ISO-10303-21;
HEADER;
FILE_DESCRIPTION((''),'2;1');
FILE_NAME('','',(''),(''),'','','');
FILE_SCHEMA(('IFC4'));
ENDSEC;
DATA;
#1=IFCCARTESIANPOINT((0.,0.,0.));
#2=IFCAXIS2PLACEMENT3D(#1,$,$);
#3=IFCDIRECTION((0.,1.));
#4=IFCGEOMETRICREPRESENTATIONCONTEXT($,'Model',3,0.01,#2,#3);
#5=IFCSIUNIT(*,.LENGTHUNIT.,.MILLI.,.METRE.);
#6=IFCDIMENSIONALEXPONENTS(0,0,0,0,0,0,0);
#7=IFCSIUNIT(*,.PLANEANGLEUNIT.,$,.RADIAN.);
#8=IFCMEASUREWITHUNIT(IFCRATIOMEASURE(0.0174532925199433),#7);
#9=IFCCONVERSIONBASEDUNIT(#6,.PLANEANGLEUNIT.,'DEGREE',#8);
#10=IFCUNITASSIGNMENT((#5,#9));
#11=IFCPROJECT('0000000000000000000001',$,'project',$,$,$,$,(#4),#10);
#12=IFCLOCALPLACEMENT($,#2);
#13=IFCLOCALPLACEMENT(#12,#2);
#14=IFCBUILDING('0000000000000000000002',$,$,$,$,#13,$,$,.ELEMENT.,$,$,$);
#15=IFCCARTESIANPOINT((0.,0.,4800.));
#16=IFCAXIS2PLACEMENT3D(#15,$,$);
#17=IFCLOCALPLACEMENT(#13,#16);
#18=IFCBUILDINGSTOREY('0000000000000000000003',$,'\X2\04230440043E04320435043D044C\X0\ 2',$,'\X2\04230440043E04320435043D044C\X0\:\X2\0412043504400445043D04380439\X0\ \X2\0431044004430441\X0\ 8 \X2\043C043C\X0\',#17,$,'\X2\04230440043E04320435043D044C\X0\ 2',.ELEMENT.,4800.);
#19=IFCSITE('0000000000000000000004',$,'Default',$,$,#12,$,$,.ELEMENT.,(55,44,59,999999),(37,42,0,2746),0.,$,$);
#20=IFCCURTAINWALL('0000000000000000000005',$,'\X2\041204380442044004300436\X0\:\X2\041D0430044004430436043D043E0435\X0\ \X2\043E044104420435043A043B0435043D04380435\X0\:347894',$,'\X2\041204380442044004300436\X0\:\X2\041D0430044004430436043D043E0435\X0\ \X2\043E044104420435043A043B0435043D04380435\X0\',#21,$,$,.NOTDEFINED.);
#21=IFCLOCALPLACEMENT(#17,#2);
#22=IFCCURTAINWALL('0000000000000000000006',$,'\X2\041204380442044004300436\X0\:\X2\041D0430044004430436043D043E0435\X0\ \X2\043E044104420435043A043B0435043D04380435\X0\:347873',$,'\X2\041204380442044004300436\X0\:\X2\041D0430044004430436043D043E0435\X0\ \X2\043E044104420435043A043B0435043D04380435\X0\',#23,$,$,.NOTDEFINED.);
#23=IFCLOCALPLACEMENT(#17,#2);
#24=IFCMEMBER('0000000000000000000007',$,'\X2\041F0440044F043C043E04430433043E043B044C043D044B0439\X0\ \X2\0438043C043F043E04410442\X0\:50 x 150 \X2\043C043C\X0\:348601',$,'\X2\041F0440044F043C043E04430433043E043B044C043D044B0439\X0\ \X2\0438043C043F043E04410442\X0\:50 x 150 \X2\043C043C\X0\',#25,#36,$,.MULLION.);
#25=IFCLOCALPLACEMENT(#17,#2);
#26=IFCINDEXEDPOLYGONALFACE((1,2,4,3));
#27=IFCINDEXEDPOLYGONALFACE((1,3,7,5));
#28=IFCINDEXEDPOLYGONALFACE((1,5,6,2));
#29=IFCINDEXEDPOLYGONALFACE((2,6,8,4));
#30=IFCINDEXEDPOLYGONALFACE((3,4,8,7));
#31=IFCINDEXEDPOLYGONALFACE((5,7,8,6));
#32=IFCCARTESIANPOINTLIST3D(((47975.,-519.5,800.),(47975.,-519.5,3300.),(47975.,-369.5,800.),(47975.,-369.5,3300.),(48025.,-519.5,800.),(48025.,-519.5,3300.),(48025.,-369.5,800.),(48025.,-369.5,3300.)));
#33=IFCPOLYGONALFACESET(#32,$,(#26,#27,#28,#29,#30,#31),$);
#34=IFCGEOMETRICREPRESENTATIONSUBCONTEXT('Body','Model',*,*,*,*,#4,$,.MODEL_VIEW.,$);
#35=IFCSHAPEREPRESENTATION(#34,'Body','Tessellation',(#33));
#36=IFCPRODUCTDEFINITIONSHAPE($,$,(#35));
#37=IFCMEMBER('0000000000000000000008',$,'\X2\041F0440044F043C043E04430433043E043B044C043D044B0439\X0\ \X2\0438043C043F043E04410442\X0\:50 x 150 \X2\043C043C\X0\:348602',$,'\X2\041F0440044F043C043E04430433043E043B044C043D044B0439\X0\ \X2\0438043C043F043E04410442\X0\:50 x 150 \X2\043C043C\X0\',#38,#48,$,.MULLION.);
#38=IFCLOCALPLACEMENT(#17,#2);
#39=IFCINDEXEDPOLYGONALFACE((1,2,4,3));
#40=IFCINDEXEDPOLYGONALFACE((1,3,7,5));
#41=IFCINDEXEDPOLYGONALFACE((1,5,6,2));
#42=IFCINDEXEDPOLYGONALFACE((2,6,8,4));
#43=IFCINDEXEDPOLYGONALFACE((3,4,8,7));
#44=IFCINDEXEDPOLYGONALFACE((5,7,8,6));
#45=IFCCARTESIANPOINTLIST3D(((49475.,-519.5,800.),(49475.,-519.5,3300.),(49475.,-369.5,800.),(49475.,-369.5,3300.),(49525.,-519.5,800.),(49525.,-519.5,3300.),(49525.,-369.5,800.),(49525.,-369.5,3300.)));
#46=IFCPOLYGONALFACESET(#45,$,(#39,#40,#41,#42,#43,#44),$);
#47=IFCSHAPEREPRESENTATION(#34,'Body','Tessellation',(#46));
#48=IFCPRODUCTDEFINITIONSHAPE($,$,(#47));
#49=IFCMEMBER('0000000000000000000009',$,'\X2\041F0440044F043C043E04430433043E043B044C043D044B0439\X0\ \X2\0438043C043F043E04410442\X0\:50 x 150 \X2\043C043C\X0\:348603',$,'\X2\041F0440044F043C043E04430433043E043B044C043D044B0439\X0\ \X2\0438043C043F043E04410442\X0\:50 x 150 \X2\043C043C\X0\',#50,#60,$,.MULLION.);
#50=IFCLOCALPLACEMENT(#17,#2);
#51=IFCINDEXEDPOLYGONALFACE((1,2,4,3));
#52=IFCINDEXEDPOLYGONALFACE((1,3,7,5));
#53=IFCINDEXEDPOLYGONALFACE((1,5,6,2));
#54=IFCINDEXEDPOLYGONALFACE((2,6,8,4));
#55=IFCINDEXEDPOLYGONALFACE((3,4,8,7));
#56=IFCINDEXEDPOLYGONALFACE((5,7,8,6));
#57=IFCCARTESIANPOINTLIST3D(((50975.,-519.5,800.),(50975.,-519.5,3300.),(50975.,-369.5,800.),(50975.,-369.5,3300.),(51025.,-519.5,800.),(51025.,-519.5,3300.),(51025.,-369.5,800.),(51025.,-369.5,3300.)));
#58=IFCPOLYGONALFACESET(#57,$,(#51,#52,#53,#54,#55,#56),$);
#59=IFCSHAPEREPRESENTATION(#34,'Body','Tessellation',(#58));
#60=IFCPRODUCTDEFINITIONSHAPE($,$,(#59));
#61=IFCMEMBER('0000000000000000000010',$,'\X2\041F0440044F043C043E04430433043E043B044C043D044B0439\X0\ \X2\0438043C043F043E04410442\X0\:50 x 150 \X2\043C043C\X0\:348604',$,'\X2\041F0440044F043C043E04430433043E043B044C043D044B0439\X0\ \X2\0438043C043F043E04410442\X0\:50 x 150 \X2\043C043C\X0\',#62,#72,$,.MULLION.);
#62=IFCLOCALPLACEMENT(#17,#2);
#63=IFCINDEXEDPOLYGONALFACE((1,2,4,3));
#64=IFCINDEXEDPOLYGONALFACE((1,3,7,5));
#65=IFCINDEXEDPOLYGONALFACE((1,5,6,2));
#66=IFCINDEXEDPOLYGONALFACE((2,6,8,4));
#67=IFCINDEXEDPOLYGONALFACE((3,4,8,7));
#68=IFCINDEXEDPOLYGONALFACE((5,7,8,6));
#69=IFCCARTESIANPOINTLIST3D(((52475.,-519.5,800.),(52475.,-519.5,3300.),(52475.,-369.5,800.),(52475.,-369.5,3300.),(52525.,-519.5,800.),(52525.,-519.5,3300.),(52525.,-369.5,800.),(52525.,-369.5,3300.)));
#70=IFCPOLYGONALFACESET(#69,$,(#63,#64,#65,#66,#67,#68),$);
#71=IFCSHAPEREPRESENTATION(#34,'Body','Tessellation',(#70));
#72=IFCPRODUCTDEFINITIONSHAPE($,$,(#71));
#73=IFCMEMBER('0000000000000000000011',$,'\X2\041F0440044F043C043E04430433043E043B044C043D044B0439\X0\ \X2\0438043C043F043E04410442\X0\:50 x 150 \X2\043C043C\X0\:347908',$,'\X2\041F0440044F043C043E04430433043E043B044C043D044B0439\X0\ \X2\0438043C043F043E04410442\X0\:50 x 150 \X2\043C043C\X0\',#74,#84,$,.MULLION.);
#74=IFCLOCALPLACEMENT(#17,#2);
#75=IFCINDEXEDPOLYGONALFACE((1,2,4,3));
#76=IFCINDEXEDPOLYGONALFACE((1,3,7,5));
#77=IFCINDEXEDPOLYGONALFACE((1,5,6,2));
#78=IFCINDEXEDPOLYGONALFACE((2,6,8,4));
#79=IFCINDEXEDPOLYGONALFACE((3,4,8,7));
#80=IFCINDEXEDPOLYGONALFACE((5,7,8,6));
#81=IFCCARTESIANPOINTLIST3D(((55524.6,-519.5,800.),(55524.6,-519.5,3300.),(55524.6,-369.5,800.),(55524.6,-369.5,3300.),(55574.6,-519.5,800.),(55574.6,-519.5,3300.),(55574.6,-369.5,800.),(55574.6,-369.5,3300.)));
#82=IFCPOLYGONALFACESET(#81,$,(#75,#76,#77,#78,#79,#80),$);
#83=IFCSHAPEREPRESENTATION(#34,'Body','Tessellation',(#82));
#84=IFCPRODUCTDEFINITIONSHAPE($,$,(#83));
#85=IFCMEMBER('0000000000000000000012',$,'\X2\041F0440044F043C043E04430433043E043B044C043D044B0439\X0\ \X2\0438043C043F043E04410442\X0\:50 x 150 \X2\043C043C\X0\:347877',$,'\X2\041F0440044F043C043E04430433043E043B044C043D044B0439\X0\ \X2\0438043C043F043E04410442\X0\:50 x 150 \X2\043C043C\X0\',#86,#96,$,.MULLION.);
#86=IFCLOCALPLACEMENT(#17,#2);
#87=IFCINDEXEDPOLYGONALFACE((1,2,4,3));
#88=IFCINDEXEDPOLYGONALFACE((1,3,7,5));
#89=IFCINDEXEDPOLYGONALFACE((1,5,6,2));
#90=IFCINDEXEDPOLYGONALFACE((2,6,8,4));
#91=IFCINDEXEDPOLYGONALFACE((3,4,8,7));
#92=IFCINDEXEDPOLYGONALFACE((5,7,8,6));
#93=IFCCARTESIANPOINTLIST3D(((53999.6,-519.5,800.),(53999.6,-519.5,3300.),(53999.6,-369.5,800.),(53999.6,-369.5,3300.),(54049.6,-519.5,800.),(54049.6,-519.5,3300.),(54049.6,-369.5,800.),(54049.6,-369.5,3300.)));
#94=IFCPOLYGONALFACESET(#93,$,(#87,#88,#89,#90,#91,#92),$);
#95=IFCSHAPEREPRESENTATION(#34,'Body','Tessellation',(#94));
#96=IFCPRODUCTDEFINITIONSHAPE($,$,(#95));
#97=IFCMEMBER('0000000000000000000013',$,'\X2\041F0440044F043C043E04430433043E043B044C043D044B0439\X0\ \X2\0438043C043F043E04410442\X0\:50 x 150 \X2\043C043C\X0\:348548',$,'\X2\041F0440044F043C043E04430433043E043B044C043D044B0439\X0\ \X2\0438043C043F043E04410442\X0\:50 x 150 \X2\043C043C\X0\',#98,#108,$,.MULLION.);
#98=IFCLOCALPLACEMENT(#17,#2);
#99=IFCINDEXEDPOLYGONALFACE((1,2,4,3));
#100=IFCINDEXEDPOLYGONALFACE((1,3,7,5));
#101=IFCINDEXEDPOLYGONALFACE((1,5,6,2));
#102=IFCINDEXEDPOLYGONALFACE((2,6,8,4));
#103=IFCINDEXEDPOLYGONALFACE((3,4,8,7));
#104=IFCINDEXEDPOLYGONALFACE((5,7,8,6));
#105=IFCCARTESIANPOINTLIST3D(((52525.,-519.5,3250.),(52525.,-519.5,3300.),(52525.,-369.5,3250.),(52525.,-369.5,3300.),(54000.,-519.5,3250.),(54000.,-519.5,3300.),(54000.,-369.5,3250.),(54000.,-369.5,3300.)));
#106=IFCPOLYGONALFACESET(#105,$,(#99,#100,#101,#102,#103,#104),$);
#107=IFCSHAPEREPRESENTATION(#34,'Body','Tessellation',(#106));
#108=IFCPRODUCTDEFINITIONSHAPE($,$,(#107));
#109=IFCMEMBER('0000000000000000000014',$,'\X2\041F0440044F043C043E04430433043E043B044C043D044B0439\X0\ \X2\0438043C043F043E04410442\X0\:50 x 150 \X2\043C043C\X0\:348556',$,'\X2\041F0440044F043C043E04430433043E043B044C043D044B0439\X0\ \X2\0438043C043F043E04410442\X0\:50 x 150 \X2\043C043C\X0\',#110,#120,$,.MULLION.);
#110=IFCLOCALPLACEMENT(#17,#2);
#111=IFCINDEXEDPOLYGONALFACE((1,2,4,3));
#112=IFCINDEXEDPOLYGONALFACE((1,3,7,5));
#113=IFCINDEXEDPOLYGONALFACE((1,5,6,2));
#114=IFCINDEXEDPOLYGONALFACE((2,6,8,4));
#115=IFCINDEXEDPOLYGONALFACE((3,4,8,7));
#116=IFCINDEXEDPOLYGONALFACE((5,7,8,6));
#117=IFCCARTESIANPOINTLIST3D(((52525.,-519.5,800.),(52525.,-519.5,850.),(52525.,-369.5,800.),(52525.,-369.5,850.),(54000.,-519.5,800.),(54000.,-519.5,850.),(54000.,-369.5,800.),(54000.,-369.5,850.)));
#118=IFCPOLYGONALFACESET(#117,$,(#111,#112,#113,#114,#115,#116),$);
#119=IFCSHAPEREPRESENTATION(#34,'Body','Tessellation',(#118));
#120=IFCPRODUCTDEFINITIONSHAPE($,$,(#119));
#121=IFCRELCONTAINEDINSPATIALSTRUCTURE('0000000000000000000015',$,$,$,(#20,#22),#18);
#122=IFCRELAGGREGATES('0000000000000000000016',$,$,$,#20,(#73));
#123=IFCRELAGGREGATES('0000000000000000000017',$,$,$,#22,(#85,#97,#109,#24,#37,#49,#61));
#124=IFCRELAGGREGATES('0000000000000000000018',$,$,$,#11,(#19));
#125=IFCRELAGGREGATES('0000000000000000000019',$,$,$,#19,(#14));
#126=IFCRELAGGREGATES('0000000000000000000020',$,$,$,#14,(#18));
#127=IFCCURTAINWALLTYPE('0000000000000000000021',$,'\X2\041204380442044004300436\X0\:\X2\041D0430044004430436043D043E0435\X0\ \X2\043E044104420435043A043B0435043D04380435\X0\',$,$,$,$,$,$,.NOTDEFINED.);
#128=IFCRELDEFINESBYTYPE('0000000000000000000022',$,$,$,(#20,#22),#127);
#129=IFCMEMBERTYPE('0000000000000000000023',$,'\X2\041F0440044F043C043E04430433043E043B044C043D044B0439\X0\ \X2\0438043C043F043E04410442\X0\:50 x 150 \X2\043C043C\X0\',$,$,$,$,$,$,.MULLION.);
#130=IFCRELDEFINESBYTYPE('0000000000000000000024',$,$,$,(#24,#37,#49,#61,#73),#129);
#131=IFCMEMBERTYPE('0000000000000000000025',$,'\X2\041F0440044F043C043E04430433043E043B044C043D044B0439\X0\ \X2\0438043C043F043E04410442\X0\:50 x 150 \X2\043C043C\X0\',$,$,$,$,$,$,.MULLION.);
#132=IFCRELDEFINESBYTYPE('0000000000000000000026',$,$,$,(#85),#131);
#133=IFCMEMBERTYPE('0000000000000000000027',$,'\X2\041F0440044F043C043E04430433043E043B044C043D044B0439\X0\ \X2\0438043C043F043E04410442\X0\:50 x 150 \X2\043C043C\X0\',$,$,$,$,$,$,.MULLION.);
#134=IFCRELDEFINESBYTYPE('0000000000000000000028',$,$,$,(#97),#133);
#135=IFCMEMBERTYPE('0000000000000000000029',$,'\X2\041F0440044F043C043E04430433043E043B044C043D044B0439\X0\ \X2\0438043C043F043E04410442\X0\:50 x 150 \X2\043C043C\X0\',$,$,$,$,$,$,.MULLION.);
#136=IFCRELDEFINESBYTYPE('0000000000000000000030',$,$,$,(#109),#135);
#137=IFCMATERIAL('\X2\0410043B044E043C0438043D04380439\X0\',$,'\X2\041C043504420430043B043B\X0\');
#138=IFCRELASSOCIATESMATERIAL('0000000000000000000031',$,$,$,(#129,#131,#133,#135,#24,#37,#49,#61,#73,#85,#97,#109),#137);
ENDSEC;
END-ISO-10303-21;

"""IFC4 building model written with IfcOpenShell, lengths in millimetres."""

from ifc_helpers import new_model, entity, si_unit, converted_unit, direction, frame, origin, origin_2d_with_axis, place, context, subcontext, project, spatial, rectangle, extrude, source, transform, mapped, material, material_profile, profile_set, profile_usage, type_object, type_shapes, element, aggregate, save


model = new_model("IFC4")

# Units and contexts
model_context = context("Model", 3, precision=0.01, world=origin(), true_north=direction((0.0, 1.0)))
body_context = subcontext(model_context, "Body", "Model", "MODEL_VIEW")
ifc_project = project(units=[si_unit("LENGTHUNIT", "METRE", prefix="MILLI"), converted_unit("PLANEANGLEUNIT", "DEGREE", entity("IfcRatioMeasure", 0.0174532925199433), si_unit("PLANEANGLEUNIT", "RADIAN"), dimensions=[0, 0, 0, 0, 0, 0, 0])], contexts=[model_context])

# Site, building, storey
site_placement = place(None, origin())
site = spatial("IfcSite", under=ifc_project, at=site_placement, Name="Default", CompositionType="ELEMENT", RefLatitude=(55, 44, 59, 999999), RefLongitude=(37, 42, 0, 2746), RefElevation=0.0)
building_placement = place(site_placement, origin())
building = spatial("IfcBuilding", under=site, at=building_placement, CompositionType="ELEMENT")
storey_placement = place(building_placement, frame((0.0, 0.0, 4800.0)))
storey = spatial("IfcBuildingStorey", under=building, at=storey_placement, Name="Уровень 2", ObjectType="Уровень:Верхний брус 8 мм", LongName="Уровень 2", CompositionType="ELEMENT", Elevation=4800.0)

# Curtain walls
curtain_wall_type = type_object("IfcCurtainWallType", Name="Витраж:Наружное остекление", PredefinedType="NOTDEFINED")
curtain_wall_1_placement = place(storey_placement, frame((0.0, 0.0, -4800.0)))
curtain_wall_1 = element("IfcCurtainWall", 1, at=curtain_wall_1_placement, inside=storey, type_object=curtain_wall_type, Name="Витраж:Наружное остекление:347894", ObjectType="Витраж:Наружное остекление", PredefinedType="NOTDEFINED")
ifc_material = material(Name="Алюминий", Category="Металл")
ifc_material_profile = material_profile(ifc_material, rectangle(XDim=150.0, YDim=50.0, at=origin_2d_with_axis()), Name="50 x 150 мм")
ifc_profile_set = profile_set([ifc_material_profile], Name="50 x 150 мм")
curtain_wall_2_placement = place(storey_placement, frame((0.0, 0.0, -4800.0)))
curtain_wall_2 = element("IfcCurtainWall", 2, at=curtain_wall_2_placement, inside=storey, type_object=curtain_wall_type, Name="Витраж:Наружное остекление:347873", ObjectType="Витраж:Наружное остекление", PredefinedType="NOTDEFINED")

# Members
member_type_1 = type_object("IfcMemberType", Name="Прямоугольный импост:50 x 150 мм", PredefinedType="MULLION", material=ifc_profile_set)
shared_shape_1 = source(origin(), body_context, "Body", "SweptSolid", [
    extrude(rectangle(XDim=150.0, YDim=50.0, at=origin_2d_with_axis()), frame((0.0, 0.0, -2500.0), z_axis=(0.0, 0.0, 1.0), x_axis=(0.0, -1.0, 0.0)), (0.0, 0.0, 1.0), 2500.0),
])
type_shapes(member_type_1, [shared_shape_1])
ifc_profile_usage_1 = profile_usage(ifc_profile_set)
member_1_placement = place(storey_placement, frame((48000.0, -444.5, 800.0), z_axis=(0.0, 0.0, -1.0), x_axis=(1.0, 0.0, 0.0)))
member_1 = element("IfcMember", 3, at=member_1_placement, type_object=member_type_1, material=ifc_profile_usage_1, Name="Прямоугольный импост:50 x 150 мм:348601", ObjectType="Прямоугольный импост:50 x 150 мм", PredefinedType="MULLION", context=body_context, shape_type="MappedRepresentation", body=[
    mapped(shared_shape_1, transform((0.0, 0.0, 0.0), scale=1.0)),
])
ifc_profile_usage_2 = profile_usage(ifc_profile_set)
member_2_placement = place(storey_placement, frame((49500.0, -444.5, 800.0), z_axis=(0.0, 0.0, -1.0), x_axis=(1.0, 0.0, 0.0)))
member_2 = element("IfcMember", 4, at=member_2_placement, type_object=member_type_1, material=ifc_profile_usage_2, Name="Прямоугольный импост:50 x 150 мм:348602", ObjectType="Прямоугольный импост:50 x 150 мм", PredefinedType="MULLION", context=body_context, shape_type="MappedRepresentation", body=[
    mapped(shared_shape_1, transform((0.0, 0.0, 0.0), scale=1.0)),
])
ifc_profile_usage_3 = profile_usage(ifc_profile_set)
member_3_placement = place(storey_placement, frame((51000.0, -444.5, 800.0), z_axis=(0.0, 0.0, -1.0), x_axis=(1.0, 0.0, 0.0)))
member_3 = element("IfcMember", 5, at=member_3_placement, type_object=member_type_1, material=ifc_profile_usage_3, Name="Прямоугольный импост:50 x 150 мм:348603", ObjectType="Прямоугольный импост:50 x 150 мм", PredefinedType="MULLION", context=body_context, shape_type="MappedRepresentation", body=[
    mapped(shared_shape_1, transform((0.0, 0.0, 0.0), scale=1.0)),
])
ifc_profile_usage_4 = profile_usage(ifc_profile_set)
member_4_placement = place(storey_placement, frame((52500.0, -444.5, 800.0), z_axis=(0.0, 0.0, -1.0), x_axis=(1.0, 0.0, 0.0)))
member_4 = element("IfcMember", 6, at=member_4_placement, type_object=member_type_1, material=ifc_profile_usage_4, Name="Прямоугольный импост:50 x 150 мм:348604", ObjectType="Прямоугольный импост:50 x 150 мм", PredefinedType="MULLION", context=body_context, shape_type="MappedRepresentation", body=[
    mapped(shared_shape_1, transform((0.0, 0.0, 0.0), scale=1.0)),
])
ifc_profile_usage_5 = profile_usage(ifc_profile_set)
member_5_placement = place(storey_placement, frame((55549.6, -444.5, 800.0), z_axis=(0.0, 0.0, -1.0), x_axis=(1.0, 0.0, 0.0)))
member_5 = element("IfcMember", 7, at=member_5_placement, type_object=member_type_1, material=ifc_profile_usage_5, Name="Прямоугольный импост:50 x 150 мм:347908", ObjectType="Прямоугольный импост:50 x 150 мм", PredefinedType="MULLION", context=body_context, shape_type="MappedRepresentation", body=[
    mapped(shared_shape_1, transform((0.0, 0.0, 0.0), scale=1.0)),
])
aggregate(curtain_wall_1, [member_5])
ifc_profile_usage_6 = profile_usage(ifc_profile_set)
member_type_2 = type_object("IfcMemberType", Name="Прямоугольный импост:50 x 150 мм", PredefinedType="MULLION", material=ifc_profile_set)
shared_shape_2 = source(origin(), body_context, "Body", "SweptSolid", [
    extrude(rectangle(XDim=150.0, YDim=50.0, at=origin_2d_with_axis()), frame((-25.0, 0.0, -2500.0), z_axis=(0.0, 0.0, 1.0), x_axis=(0.0, -1.0, 0.0)), (0.0, 0.0, 1.0), 2500.0),
])
type_shapes(member_type_2, [shared_shape_2])
member_6_placement = place(storey_placement, frame((54049.6, -444.5, 800.0), z_axis=(0.0, 0.0, -1.0), x_axis=(1.0, 0.0, 0.0)))
member_6 = element("IfcMember", 8, at=member_6_placement, type_object=member_type_2, material=ifc_profile_usage_6, Name="Прямоугольный импост:50 x 150 мм:347877", ObjectType="Прямоугольный импост:50 x 150 мм", PredefinedType="MULLION", context=body_context, shape_type="MappedRepresentation", body=[
    mapped(shared_shape_2, transform((0.0, 0.0, 0.0), scale=1.0)),
])
ifc_profile_usage_7 = profile_usage(ifc_profile_set)
member_type_3 = type_object("IfcMemberType", Name="Прямоугольный импост:50 x 150 мм", PredefinedType="MULLION", material=ifc_profile_set)
shared_shape_3 = source(origin(), body_context, "Body", "SweptSolid", [
    extrude(rectangle(XDim=150.0, YDim=50.0, at=origin_2d_with_axis()), frame((-25.0, 0.0, -1475.0), z_axis=(0.0, 0.0, 1.0), x_axis=(0.0, -1.0, 0.0)), (0.0, 0.0, 1.0), 1475.0),
])
type_shapes(member_type_3, [shared_shape_3])
member_7_placement = place(storey_placement, frame((54000.0, -444.5, 3300.0), z_axis=(1.0, 0.0, 0.0), x_axis=(0.0, 0.0, 1.0)))
member_7 = element("IfcMember", 9, at=member_7_placement, type_object=member_type_3, material=ifc_profile_usage_7, Name="Прямоугольный импост:50 x 150 мм:348548", ObjectType="Прямоугольный импост:50 x 150 мм", PredefinedType="MULLION", context=body_context, shape_type="MappedRepresentation", body=[
    mapped(shared_shape_3, transform((0.0, 0.0, 0.0), scale=1.0)),
])
ifc_profile_usage_8 = profile_usage(ifc_profile_set)
member_type_4 = type_object("IfcMemberType", Name="Прямоугольный импост:50 x 150 мм", PredefinedType="MULLION", material=ifc_profile_set)
shared_shape_4 = source(origin(), body_context, "Body", "SweptSolid", [
    extrude(rectangle(XDim=150.0, YDim=50.0, at=origin_2d_with_axis()), frame((-25.0, 0.0, -1475.0), z_axis=(0.0, 0.0, 1.0), x_axis=(0.0, -1.0, 0.0)), (0.0, 0.0, 1.0), 1475.0),
])
type_shapes(member_type_4, [shared_shape_4])
member_8_placement = place(storey_placement, frame((52525.0, -444.5, 800.0), z_axis=(-1.0, 0.0, 0.0), x_axis=(0.0, 0.0, -1.0)))
member_8 = element("IfcMember", 10, at=member_8_placement, type_object=member_type_4, material=ifc_profile_usage_8, Name="Прямоугольный импост:50 x 150 мм:348556", ObjectType="Прямоугольный импост:50 x 150 мм", PredefinedType="MULLION", context=body_context, shape_type="MappedRepresentation", body=[
    mapped(shared_shape_4, transform((0.0, 0.0, 0.0), scale=1.0)),
])
aggregate(curtain_wall_2, [member_6, member_7, member_8, member_1, member_2, member_3, member_4])

save(model, "model.ifc")
